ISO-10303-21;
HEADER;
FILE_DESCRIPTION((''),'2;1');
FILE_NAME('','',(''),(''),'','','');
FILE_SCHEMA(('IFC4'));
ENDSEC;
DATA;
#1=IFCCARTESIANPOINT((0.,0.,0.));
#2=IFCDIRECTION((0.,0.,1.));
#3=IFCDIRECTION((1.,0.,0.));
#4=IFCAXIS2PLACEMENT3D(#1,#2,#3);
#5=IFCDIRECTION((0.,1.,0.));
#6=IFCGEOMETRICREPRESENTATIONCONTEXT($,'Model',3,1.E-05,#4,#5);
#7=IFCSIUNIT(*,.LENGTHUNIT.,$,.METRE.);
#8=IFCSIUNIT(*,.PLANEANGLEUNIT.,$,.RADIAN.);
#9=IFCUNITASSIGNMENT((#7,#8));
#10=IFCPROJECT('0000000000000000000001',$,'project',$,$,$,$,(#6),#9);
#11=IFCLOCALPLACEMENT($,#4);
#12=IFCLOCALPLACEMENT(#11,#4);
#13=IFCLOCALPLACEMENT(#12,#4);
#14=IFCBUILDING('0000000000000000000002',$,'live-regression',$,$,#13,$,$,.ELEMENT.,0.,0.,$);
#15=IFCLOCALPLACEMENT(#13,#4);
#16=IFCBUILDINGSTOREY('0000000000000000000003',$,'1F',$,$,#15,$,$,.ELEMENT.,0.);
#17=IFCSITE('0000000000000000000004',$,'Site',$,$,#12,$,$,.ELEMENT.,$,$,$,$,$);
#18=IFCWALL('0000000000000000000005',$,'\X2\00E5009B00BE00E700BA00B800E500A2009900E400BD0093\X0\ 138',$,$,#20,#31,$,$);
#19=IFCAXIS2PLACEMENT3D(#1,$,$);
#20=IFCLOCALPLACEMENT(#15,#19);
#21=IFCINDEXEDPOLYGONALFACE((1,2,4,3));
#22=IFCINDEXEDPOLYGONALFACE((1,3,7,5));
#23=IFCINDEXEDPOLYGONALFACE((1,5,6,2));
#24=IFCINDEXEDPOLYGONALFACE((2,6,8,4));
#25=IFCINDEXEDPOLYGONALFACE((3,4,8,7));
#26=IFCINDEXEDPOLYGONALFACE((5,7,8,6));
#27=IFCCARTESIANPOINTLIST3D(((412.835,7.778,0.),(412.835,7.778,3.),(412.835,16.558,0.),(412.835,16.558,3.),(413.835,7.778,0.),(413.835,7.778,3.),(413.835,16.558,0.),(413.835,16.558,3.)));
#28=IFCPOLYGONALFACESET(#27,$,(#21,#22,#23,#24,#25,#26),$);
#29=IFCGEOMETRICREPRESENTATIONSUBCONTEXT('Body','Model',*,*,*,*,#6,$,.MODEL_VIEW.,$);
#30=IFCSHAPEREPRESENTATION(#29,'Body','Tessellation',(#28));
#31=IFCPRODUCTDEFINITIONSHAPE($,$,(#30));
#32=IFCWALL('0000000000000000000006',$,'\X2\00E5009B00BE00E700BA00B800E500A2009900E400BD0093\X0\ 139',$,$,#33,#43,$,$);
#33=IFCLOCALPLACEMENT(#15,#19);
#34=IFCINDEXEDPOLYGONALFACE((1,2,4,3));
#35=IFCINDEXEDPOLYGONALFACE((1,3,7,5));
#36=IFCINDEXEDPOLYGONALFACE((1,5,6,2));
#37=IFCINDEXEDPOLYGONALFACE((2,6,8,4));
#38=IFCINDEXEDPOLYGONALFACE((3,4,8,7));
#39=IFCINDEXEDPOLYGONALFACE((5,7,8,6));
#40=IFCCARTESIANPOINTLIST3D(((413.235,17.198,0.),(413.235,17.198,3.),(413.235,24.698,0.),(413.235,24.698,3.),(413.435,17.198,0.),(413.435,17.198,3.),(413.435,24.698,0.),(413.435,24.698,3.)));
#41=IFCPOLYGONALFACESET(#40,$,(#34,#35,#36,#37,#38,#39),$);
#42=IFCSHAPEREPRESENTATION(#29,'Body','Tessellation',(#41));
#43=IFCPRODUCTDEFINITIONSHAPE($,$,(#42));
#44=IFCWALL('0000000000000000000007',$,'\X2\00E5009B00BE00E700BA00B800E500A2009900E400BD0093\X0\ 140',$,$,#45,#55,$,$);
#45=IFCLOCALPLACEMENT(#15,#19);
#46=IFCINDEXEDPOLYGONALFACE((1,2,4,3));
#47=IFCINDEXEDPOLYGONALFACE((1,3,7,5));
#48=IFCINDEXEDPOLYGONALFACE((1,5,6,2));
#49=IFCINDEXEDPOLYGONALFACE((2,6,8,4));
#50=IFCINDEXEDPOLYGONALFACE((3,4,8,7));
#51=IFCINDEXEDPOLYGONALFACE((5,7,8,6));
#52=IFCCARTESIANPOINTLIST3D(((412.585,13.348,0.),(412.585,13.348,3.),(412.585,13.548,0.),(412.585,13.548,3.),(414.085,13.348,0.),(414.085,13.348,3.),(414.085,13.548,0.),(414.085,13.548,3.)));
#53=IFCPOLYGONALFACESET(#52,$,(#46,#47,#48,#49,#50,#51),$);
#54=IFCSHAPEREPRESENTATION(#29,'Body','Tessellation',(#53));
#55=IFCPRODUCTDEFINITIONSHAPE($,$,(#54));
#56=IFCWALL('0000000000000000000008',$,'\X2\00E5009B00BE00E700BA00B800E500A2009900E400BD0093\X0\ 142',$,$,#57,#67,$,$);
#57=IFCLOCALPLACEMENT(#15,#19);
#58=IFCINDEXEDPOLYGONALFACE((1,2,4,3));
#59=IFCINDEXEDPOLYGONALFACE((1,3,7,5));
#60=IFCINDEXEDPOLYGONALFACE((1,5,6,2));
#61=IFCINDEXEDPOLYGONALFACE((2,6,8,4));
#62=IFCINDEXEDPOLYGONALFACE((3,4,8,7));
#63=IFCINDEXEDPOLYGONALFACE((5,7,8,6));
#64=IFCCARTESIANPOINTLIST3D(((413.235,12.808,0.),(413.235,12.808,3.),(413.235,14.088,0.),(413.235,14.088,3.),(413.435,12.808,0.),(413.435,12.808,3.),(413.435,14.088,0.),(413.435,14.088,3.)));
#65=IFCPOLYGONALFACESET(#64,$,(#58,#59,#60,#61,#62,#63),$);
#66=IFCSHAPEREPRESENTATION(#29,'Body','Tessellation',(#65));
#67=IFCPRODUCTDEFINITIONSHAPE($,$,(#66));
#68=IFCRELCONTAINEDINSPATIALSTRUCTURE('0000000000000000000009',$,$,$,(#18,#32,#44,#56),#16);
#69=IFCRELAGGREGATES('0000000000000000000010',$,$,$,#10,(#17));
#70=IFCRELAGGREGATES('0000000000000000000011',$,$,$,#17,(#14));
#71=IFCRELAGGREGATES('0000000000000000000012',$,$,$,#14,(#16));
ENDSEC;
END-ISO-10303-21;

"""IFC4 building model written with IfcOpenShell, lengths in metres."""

from ifc_helpers import new_model, si_unit, direction, frame, frame_2d, origin_with_axes, place, context, subcontext, project, spatial, rectangle, extrude, element, save


model = new_model("IFC4")

# Units and contexts
model_context = context("Model", 3, precision=1e-05, world=origin_with_axes(), true_north=direction((0.0, 1.0, 0.0)))
body_context = subcontext(model_context, "Body", "Model", "MODEL_VIEW")
ifc_project = project(units=[si_unit("LENGTHUNIT", "METRE"), si_unit("PLANEANGLEUNIT", "RADIAN")], contexts=[model_context])

# Site, building, storey
placement = place(None, origin_with_axes())
site_placement = place(placement, origin_with_axes())
site = spatial("IfcSite", under=ifc_project, at=site_placement, Name="Site", CompositionType="ELEMENT")
building_placement = place(site_placement, origin_with_axes())
building = spatial("IfcBuilding", under=site, at=building_placement, Name="live-regression", CompositionType="ELEMENT", ElevationOfRefHeight=0.0, ElevationOfTerrain=0.0)
storey_placement = place(building_placement, origin_with_axes())
storey = spatial("IfcBuildingStorey", under=building, at=storey_placement, Name="1F", CompositionType="ELEMENT", Elevation=0.0)

# Walls
wall_1_placement = place(storey_placement, frame((413.335, 12.168, 0.0), z_axis=(0.0, 0.0, 1.0), x_axis=(1.0, 0.0, 0.0)))
element("IfcWall", 1, at=wall_1_placement, inside=storey, Name="å\u009b¾çº¸å¢\u0099ä½\u0093 138", context=body_context, shape_type="SweptSolid", body=[
    extrude(rectangle(XDim=1.0, YDim=8.78, at=frame_2d((0.0, 0.0), x_axis=(1.0, 0.0, 0.0))), frame((0.0, 0.0, 0.0), z_axis=(0.0, 0.0, 1.0)), (0.0, 0.0, 1.0), 3.0),
])
wall_2_placement = place(storey_placement, frame((413.335, 20.948, 0.0), z_axis=(0.0, 0.0, 1.0), x_axis=(0.0, -1.0, 0.0)))
element("IfcWall", 2, at=wall_2_placement, inside=storey, Name="å\u009b¾çº¸å¢\u0099ä½\u0093 139", context=body_context, shape_type="SweptSolid", body=[
    extrude(rectangle(XDim=7.5, YDim=0.2, at=frame_2d((0.0, 0.0), x_axis=(1.0, 0.0, 0.0))), frame((0.0, 0.0, 0.0), z_axis=(0.0, 0.0, 1.0)), (0.0, 0.0, 1.0), 3.0),
])
wall_3_placement = place(storey_placement, frame((413.335, 13.448, 0.0), z_axis=(0.0, 0.0, 1.0), x_axis=(1.0, 0.0, 0.0)))
element("IfcWall", 3, at=wall_3_placement, inside=storey, Name="å\u009b¾çº¸å¢\u0099ä½\u0093 140", context=body_context, shape_type="SweptSolid", body=[
    extrude(rectangle(XDim=1.5, YDim=0.2, at=frame_2d((0.0, 0.0), x_axis=(1.0, 0.0, 0.0))), frame((0.0, 0.0, 0.0), z_axis=(0.0, 0.0, 1.0)), (0.0, 0.0, 1.0), 3.0),
])
wall_4_placement = place(storey_placement, frame((413.335, 13.448, 0.0), z_axis=(0.0, 0.0, 1.0), x_axis=(0.0, -1.0, 0.0)))
element("IfcWall", 4, at=wall_4_placement, inside=storey, Name="å\u009b¾çº¸å¢\u0099ä½\u0093 142", context=body_context, shape_type="SweptSolid", body=[
    extrude(rectangle(XDim=1.28, YDim=0.2, at=frame_2d((0.0, 0.0), x_axis=(1.0, 0.0, 0.0))), frame((0.0, 0.0, 0.0), z_axis=(0.0, 0.0, 1.0)), (0.0, 0.0, 1.0), 3.0),
])

save(model, "model.ifc")
